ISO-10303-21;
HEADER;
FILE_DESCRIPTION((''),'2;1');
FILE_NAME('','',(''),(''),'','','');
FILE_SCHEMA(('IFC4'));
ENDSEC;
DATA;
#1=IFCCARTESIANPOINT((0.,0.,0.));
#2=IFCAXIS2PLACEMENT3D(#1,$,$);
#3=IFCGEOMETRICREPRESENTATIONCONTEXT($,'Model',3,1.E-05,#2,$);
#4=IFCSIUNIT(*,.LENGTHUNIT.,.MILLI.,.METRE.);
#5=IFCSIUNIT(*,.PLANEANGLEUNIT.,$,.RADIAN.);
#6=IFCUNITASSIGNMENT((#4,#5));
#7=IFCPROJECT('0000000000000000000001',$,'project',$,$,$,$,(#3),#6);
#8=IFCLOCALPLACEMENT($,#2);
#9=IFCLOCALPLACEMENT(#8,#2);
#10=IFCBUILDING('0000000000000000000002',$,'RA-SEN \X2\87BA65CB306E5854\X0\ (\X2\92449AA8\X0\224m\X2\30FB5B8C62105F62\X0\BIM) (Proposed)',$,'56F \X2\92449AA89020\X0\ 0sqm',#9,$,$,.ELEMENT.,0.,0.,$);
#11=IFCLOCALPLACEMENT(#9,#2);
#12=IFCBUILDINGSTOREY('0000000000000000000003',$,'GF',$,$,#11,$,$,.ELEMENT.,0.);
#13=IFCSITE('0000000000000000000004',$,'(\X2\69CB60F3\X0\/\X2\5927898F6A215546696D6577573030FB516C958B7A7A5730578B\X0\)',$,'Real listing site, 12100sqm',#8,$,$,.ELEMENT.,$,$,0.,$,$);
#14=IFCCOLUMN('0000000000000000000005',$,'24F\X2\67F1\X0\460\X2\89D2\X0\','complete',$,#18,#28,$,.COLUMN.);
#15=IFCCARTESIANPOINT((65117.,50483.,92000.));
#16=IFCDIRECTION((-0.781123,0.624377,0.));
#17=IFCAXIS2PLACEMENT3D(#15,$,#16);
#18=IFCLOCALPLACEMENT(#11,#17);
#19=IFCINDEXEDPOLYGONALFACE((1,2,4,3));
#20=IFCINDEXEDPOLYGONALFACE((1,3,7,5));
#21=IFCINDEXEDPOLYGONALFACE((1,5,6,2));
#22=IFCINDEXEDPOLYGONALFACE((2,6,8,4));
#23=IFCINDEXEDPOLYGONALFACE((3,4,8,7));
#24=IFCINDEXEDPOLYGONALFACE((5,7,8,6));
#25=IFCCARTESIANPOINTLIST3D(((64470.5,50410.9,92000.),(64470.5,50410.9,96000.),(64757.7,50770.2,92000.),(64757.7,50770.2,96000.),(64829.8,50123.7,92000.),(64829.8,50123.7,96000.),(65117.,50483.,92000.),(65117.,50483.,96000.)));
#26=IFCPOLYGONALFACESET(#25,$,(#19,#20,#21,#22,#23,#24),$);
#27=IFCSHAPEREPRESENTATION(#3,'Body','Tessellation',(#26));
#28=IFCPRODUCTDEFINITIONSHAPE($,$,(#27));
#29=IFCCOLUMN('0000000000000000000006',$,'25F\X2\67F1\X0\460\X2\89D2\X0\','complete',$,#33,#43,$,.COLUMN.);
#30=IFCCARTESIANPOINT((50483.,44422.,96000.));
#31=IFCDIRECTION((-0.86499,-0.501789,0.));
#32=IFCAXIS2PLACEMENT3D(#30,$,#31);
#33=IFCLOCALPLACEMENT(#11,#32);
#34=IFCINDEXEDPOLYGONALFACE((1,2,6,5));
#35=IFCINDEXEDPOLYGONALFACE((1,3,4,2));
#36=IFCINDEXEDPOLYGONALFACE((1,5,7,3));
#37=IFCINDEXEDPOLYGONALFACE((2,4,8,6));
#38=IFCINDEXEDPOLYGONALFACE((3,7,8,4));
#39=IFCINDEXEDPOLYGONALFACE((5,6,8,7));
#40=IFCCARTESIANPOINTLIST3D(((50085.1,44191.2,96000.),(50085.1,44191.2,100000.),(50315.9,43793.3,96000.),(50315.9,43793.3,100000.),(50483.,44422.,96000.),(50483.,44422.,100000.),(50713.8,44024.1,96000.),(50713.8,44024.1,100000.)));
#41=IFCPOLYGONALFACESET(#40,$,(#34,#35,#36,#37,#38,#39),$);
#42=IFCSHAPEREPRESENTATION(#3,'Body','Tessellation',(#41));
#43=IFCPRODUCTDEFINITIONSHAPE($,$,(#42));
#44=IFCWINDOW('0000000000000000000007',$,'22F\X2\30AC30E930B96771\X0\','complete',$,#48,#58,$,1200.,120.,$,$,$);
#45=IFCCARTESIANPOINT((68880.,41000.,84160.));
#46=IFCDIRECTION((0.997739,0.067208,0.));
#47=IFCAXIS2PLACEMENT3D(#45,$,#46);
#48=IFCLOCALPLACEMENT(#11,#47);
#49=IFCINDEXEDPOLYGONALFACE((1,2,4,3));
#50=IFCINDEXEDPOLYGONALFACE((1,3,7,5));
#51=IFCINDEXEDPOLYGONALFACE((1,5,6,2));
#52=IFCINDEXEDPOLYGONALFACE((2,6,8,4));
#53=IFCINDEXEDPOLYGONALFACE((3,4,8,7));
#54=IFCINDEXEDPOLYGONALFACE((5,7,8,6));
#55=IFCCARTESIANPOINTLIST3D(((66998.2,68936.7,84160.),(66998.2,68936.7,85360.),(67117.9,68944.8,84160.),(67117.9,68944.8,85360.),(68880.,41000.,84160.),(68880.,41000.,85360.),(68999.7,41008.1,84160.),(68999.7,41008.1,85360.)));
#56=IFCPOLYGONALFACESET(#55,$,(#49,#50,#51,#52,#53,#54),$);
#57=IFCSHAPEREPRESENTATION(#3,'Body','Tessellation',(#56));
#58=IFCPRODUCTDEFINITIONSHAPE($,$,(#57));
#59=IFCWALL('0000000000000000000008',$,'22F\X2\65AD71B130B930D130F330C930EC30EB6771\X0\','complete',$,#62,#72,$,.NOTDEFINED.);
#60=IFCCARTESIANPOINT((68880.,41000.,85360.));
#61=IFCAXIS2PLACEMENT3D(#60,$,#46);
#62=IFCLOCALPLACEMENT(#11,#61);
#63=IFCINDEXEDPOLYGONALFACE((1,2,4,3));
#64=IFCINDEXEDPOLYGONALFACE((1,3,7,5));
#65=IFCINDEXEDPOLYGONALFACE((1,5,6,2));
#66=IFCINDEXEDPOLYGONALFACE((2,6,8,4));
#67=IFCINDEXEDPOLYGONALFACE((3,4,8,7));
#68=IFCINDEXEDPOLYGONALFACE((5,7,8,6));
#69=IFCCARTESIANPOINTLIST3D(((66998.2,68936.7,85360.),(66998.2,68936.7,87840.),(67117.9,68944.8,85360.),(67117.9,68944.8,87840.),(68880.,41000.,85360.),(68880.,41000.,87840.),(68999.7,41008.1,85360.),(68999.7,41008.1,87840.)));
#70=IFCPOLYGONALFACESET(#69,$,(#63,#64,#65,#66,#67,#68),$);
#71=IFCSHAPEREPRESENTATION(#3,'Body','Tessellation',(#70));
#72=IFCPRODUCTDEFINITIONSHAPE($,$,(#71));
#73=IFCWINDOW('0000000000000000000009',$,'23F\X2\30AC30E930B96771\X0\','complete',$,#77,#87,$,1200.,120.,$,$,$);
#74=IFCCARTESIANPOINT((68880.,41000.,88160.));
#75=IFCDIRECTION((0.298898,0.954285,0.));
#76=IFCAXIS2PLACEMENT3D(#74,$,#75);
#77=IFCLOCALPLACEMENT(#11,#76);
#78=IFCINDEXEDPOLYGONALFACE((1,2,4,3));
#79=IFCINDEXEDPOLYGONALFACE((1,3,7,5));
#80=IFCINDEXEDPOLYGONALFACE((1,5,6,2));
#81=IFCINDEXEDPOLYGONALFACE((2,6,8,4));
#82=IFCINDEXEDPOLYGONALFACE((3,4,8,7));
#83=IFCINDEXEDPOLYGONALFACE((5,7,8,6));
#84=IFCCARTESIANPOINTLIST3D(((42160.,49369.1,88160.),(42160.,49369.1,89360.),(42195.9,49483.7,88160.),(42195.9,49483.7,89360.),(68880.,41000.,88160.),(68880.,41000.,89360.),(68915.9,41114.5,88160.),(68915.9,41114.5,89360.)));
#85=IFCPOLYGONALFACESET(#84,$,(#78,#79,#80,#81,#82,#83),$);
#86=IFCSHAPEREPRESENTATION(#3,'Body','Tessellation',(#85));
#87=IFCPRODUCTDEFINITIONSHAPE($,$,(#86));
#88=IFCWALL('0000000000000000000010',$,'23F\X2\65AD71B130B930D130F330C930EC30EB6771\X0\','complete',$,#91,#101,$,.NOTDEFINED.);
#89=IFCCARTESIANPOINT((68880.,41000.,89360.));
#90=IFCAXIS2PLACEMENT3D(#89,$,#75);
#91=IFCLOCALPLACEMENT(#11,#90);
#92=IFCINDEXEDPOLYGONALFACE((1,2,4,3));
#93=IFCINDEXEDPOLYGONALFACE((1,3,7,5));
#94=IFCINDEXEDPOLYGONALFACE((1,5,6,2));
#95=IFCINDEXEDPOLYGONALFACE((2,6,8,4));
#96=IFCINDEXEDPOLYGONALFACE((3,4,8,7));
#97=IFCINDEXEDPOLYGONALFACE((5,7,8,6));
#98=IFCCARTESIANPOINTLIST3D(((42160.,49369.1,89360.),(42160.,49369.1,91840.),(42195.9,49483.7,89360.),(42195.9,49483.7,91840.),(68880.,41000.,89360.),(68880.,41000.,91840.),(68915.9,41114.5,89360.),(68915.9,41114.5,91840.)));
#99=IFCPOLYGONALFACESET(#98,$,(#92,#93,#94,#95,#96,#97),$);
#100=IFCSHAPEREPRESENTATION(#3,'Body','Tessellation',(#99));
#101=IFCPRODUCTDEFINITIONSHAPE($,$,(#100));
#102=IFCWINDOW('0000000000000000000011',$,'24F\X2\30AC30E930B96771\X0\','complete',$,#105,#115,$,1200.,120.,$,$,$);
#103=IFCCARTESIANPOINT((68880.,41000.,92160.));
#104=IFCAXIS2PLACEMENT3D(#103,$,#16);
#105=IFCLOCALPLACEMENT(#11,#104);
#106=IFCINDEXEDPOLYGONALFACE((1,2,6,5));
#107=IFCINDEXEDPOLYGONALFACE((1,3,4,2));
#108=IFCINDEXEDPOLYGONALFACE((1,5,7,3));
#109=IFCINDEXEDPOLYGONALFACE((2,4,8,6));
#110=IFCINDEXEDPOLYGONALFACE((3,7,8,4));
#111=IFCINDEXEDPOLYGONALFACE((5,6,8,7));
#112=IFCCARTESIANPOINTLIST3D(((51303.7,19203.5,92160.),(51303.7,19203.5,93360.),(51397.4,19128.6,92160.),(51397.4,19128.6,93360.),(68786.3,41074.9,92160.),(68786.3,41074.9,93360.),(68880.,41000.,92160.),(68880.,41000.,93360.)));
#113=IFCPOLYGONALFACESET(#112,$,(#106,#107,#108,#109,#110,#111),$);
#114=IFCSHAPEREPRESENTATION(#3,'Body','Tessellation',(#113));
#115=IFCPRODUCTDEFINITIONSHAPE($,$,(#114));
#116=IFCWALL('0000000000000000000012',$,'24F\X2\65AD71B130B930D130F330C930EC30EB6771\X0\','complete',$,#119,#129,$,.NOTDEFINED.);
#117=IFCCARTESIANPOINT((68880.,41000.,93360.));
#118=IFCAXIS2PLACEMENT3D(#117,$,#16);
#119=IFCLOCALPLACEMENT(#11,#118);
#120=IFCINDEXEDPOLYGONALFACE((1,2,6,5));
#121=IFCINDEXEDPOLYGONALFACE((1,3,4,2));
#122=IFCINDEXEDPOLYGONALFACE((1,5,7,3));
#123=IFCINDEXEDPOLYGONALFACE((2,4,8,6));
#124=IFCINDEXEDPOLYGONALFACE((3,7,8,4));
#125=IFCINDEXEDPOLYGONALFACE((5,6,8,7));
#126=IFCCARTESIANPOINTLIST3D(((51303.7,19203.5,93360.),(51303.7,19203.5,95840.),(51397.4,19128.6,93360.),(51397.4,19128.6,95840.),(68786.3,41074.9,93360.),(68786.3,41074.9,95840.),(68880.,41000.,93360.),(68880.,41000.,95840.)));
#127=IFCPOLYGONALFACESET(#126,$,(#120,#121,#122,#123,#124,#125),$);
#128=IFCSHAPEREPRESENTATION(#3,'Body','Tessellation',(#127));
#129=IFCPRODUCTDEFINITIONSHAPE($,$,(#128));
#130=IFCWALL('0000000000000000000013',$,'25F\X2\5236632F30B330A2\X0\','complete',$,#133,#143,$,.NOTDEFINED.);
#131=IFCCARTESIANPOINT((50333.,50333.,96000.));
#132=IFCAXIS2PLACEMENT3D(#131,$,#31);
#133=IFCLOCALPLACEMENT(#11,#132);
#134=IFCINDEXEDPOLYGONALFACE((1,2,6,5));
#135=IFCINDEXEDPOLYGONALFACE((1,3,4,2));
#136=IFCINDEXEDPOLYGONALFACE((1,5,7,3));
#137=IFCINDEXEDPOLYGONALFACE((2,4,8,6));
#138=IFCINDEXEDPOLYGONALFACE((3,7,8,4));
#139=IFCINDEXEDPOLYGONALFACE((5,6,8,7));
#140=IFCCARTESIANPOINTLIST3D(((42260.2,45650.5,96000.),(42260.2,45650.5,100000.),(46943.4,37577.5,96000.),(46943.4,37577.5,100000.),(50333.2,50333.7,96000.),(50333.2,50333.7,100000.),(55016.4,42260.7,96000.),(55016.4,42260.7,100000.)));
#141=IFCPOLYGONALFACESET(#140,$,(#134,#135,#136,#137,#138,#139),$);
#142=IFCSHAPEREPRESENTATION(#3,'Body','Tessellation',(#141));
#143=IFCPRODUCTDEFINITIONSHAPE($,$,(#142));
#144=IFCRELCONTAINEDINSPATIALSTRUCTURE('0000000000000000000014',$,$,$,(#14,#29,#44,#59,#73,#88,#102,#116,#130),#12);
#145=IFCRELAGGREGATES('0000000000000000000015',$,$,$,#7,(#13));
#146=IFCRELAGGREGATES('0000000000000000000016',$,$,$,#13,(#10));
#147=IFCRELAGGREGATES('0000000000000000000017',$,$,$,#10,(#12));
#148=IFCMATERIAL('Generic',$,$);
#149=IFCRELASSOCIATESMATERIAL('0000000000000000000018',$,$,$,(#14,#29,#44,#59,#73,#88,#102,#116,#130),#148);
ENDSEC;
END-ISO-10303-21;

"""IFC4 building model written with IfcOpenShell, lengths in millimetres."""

from ifc_helpers import new_model, si_unit, frame, frame_2d, origin, place, context, project, spatial, rectangle, extrude, material, element, save


model = new_model("IFC4")

# Units and contexts
model_context = context("Model", 3, precision=1e-05, world=origin())
ifc_project = project(units=[si_unit("LENGTHUNIT", "METRE", prefix="MILLI"), si_unit("PLANEANGLEUNIT", "RADIAN")], contexts=[model_context])

# Site, building, storey
site_placement = place(None, origin())
site = spatial("IfcSite", under=ifc_project, at=site_placement, Name="(構想/大規模商業敷地・公開空地型)", ObjectType="Real listing site, 12100sqm", CompositionType="ELEMENT", RefElevation=0.0)
building_placement = place(site_placement, origin())
building = spatial("IfcBuilding", under=site, at=building_placement, Name="RA-SEN 螺旋の塔 (鉄骨224m・完成形BIM) (Proposed)", ObjectType="56F 鉄骨造 0sqm", CompositionType="ELEMENT", ElevationOfRefHeight=0.0, ElevationOfTerrain=0.0)
storey_placement = place(building_placement, origin())
storey = spatial("IfcBuildingStorey", under=building, at=storey_placement, Name="GF", CompositionType="ELEMENT", Elevation=0.0)

# Columns
ifc_material = material(Name="Generic")
column_1_placement = place(storey_placement, frame((65117.0, 50483.0, 92000.0), x_axis=(-0.781123, 0.624377, 0.0)))
element("IfcColumn", 1, at=column_1_placement, inside=storey, material=ifc_material, Name="24F柱460角", Description="complete", PredefinedType="COLUMN", context=model_context, shape_type="SweptSolid", body=[
    extrude(rectangle(XDim=460.0, YDim=460.0, at=frame_2d((230.0, 230.0))), frame((65117.0, 50483.0, 92000.0), x_axis=(-0.781123, 0.624377, 0.0)), (0.0, 0.0, 1.0), 4000.0),
])
column_2_placement = place(storey_placement, frame((50483.0, 44422.0, 96000.0), x_axis=(-0.86499, -0.501789, 0.0)))
element("IfcColumn", 2, at=column_2_placement, inside=storey, material=ifc_material, Name="25F柱460角", Description="complete", PredefinedType="COLUMN", context=model_context, shape_type="SweptSolid", body=[
    extrude(rectangle(XDim=460.0, YDim=460.0, at=frame_2d((230.0, 230.0))), frame((50483.0, 44422.0, 96000.0), x_axis=(-0.86499, -0.501789, 0.0)), (0.0, 0.0, 1.0), 4000.0),
])

# Window
window_1_placement = place(storey_placement, frame((68880.0, 41000.0, 84160.0), x_axis=(0.997739, 0.067208, 0.0)))
element("IfcWindow", 3, at=window_1_placement, inside=storey, material=ifc_material, Name="22Fガラス東", Description="complete", OverallHeight=1200.0, OverallWidth=120.0, context=model_context, shape_type="SweptSolid", body=[
    extrude(rectangle(XDim=120.0, YDim=28000.0, at=frame_2d((60.0, 14000.0))), frame((68880.0, 41000.0, 84160.0), x_axis=(0.997739, 0.067208, 0.0)), (0.0, 0.0, 1.0), 1200.0),
])

# Wall
wall_1_placement = place(storey_placement, frame((68880.0, 41000.0, 85360.0), x_axis=(0.997739, 0.067208, 0.0)))
element("IfcWall", 4, at=wall_1_placement, inside=storey, material=ifc_material, Name="22F断熱スパンドレル東", Description="complete", PredefinedType="NOTDEFINED", context=model_context, shape_type="SweptSolid", body=[
    extrude(rectangle(XDim=120.0, YDim=28000.0, at=frame_2d((60.0, 14000.0))), frame((68880.0, 41000.0, 85360.0), x_axis=(0.997739, 0.067208, 0.0)), (0.0, 0.0, 1.0), 2480.0),
])

# Window
window_2_placement = place(storey_placement, frame((68880.0, 41000.0, 88160.0), x_axis=(0.298898, 0.954285, 0.0)))
element("IfcWindow", 5, at=window_2_placement, inside=storey, material=ifc_material, Name="23Fガラス東", Description="complete", OverallHeight=1200.0, OverallWidth=120.0, context=model_context, shape_type="SweptSolid", body=[
    extrude(rectangle(XDim=120.0, YDim=28000.0, at=frame_2d((60.0, 14000.0))), frame((68880.0, 41000.0, 88160.0), x_axis=(0.298898, 0.954285, 0.0)), (0.0, 0.0, 1.0), 1200.0),
])

# Wall
wall_2_placement = place(storey_placement, frame((68880.0, 41000.0, 89360.0), x_axis=(0.298898, 0.954285, 0.0)))
element("IfcWall", 6, at=wall_2_placement, inside=storey, material=ifc_material, Name="23F断熱スパンドレル東", Description="complete", PredefinedType="NOTDEFINED", context=model_context, shape_type="SweptSolid", body=[
    extrude(rectangle(XDim=120.0, YDim=28000.0, at=frame_2d((60.0, 14000.0))), frame((68880.0, 41000.0, 89360.0), x_axis=(0.298898, 0.954285, 0.0)), (0.0, 0.0, 1.0), 2480.0),
])

# Window
window_3_placement = place(storey_placement, frame((68880.0, 41000.0, 92160.0), x_axis=(-0.781123, 0.624377, 0.0)))
element("IfcWindow", 7, at=window_3_placement, inside=storey, material=ifc_material, Name="24Fガラス東", Description="complete", OverallHeight=1200.0, OverallWidth=120.0, context=model_context, shape_type="SweptSolid", body=[
    extrude(rectangle(XDim=120.0, YDim=28000.0, at=frame_2d((60.0, 14000.0))), frame((68880.0, 41000.0, 92160.0), x_axis=(-0.781123, 0.624377, 0.0)), (0.0, 0.0, 1.0), 1200.0),
])

# Walls
wall_3_placement = place(storey_placement, frame((68880.0, 41000.0, 93360.0), x_axis=(-0.781123, 0.624377, 0.0)))
element("IfcWall", 8, at=wall_3_placement, inside=storey, material=ifc_material, Name="24F断熱スパンドレル東", Description="complete", PredefinedType="NOTDEFINED", context=model_context, shape_type="SweptSolid", body=[
    extrude(rectangle(XDim=120.0, YDim=28000.0, at=frame_2d((60.0, 14000.0))), frame((68880.0, 41000.0, 93360.0), x_axis=(-0.781123, 0.624377, 0.0)), (0.0, 0.0, 1.0), 2480.0),
])
wall_4_placement = place(storey_placement, frame((50333.0, 50333.0, 96000.0), x_axis=(-0.86499, -0.501789, 0.0)))
element("IfcWall", 9, at=wall_4_placement, inside=storey, material=ifc_material, Name="25F制振コア", Description="complete", PredefinedType="NOTDEFINED", context=model_context, shape_type="SweptSolid", body=[
    extrude(rectangle(XDim=9333.0, YDim=9333.0, at=frame_2d((4666.0, 4666.0))), frame((50333.0, 50333.0, 96000.0), x_axis=(-0.86499, -0.501789, 0.0)), (0.0, 0.0, 1.0), 4000.0),
])

save(model, "model.ifc")
